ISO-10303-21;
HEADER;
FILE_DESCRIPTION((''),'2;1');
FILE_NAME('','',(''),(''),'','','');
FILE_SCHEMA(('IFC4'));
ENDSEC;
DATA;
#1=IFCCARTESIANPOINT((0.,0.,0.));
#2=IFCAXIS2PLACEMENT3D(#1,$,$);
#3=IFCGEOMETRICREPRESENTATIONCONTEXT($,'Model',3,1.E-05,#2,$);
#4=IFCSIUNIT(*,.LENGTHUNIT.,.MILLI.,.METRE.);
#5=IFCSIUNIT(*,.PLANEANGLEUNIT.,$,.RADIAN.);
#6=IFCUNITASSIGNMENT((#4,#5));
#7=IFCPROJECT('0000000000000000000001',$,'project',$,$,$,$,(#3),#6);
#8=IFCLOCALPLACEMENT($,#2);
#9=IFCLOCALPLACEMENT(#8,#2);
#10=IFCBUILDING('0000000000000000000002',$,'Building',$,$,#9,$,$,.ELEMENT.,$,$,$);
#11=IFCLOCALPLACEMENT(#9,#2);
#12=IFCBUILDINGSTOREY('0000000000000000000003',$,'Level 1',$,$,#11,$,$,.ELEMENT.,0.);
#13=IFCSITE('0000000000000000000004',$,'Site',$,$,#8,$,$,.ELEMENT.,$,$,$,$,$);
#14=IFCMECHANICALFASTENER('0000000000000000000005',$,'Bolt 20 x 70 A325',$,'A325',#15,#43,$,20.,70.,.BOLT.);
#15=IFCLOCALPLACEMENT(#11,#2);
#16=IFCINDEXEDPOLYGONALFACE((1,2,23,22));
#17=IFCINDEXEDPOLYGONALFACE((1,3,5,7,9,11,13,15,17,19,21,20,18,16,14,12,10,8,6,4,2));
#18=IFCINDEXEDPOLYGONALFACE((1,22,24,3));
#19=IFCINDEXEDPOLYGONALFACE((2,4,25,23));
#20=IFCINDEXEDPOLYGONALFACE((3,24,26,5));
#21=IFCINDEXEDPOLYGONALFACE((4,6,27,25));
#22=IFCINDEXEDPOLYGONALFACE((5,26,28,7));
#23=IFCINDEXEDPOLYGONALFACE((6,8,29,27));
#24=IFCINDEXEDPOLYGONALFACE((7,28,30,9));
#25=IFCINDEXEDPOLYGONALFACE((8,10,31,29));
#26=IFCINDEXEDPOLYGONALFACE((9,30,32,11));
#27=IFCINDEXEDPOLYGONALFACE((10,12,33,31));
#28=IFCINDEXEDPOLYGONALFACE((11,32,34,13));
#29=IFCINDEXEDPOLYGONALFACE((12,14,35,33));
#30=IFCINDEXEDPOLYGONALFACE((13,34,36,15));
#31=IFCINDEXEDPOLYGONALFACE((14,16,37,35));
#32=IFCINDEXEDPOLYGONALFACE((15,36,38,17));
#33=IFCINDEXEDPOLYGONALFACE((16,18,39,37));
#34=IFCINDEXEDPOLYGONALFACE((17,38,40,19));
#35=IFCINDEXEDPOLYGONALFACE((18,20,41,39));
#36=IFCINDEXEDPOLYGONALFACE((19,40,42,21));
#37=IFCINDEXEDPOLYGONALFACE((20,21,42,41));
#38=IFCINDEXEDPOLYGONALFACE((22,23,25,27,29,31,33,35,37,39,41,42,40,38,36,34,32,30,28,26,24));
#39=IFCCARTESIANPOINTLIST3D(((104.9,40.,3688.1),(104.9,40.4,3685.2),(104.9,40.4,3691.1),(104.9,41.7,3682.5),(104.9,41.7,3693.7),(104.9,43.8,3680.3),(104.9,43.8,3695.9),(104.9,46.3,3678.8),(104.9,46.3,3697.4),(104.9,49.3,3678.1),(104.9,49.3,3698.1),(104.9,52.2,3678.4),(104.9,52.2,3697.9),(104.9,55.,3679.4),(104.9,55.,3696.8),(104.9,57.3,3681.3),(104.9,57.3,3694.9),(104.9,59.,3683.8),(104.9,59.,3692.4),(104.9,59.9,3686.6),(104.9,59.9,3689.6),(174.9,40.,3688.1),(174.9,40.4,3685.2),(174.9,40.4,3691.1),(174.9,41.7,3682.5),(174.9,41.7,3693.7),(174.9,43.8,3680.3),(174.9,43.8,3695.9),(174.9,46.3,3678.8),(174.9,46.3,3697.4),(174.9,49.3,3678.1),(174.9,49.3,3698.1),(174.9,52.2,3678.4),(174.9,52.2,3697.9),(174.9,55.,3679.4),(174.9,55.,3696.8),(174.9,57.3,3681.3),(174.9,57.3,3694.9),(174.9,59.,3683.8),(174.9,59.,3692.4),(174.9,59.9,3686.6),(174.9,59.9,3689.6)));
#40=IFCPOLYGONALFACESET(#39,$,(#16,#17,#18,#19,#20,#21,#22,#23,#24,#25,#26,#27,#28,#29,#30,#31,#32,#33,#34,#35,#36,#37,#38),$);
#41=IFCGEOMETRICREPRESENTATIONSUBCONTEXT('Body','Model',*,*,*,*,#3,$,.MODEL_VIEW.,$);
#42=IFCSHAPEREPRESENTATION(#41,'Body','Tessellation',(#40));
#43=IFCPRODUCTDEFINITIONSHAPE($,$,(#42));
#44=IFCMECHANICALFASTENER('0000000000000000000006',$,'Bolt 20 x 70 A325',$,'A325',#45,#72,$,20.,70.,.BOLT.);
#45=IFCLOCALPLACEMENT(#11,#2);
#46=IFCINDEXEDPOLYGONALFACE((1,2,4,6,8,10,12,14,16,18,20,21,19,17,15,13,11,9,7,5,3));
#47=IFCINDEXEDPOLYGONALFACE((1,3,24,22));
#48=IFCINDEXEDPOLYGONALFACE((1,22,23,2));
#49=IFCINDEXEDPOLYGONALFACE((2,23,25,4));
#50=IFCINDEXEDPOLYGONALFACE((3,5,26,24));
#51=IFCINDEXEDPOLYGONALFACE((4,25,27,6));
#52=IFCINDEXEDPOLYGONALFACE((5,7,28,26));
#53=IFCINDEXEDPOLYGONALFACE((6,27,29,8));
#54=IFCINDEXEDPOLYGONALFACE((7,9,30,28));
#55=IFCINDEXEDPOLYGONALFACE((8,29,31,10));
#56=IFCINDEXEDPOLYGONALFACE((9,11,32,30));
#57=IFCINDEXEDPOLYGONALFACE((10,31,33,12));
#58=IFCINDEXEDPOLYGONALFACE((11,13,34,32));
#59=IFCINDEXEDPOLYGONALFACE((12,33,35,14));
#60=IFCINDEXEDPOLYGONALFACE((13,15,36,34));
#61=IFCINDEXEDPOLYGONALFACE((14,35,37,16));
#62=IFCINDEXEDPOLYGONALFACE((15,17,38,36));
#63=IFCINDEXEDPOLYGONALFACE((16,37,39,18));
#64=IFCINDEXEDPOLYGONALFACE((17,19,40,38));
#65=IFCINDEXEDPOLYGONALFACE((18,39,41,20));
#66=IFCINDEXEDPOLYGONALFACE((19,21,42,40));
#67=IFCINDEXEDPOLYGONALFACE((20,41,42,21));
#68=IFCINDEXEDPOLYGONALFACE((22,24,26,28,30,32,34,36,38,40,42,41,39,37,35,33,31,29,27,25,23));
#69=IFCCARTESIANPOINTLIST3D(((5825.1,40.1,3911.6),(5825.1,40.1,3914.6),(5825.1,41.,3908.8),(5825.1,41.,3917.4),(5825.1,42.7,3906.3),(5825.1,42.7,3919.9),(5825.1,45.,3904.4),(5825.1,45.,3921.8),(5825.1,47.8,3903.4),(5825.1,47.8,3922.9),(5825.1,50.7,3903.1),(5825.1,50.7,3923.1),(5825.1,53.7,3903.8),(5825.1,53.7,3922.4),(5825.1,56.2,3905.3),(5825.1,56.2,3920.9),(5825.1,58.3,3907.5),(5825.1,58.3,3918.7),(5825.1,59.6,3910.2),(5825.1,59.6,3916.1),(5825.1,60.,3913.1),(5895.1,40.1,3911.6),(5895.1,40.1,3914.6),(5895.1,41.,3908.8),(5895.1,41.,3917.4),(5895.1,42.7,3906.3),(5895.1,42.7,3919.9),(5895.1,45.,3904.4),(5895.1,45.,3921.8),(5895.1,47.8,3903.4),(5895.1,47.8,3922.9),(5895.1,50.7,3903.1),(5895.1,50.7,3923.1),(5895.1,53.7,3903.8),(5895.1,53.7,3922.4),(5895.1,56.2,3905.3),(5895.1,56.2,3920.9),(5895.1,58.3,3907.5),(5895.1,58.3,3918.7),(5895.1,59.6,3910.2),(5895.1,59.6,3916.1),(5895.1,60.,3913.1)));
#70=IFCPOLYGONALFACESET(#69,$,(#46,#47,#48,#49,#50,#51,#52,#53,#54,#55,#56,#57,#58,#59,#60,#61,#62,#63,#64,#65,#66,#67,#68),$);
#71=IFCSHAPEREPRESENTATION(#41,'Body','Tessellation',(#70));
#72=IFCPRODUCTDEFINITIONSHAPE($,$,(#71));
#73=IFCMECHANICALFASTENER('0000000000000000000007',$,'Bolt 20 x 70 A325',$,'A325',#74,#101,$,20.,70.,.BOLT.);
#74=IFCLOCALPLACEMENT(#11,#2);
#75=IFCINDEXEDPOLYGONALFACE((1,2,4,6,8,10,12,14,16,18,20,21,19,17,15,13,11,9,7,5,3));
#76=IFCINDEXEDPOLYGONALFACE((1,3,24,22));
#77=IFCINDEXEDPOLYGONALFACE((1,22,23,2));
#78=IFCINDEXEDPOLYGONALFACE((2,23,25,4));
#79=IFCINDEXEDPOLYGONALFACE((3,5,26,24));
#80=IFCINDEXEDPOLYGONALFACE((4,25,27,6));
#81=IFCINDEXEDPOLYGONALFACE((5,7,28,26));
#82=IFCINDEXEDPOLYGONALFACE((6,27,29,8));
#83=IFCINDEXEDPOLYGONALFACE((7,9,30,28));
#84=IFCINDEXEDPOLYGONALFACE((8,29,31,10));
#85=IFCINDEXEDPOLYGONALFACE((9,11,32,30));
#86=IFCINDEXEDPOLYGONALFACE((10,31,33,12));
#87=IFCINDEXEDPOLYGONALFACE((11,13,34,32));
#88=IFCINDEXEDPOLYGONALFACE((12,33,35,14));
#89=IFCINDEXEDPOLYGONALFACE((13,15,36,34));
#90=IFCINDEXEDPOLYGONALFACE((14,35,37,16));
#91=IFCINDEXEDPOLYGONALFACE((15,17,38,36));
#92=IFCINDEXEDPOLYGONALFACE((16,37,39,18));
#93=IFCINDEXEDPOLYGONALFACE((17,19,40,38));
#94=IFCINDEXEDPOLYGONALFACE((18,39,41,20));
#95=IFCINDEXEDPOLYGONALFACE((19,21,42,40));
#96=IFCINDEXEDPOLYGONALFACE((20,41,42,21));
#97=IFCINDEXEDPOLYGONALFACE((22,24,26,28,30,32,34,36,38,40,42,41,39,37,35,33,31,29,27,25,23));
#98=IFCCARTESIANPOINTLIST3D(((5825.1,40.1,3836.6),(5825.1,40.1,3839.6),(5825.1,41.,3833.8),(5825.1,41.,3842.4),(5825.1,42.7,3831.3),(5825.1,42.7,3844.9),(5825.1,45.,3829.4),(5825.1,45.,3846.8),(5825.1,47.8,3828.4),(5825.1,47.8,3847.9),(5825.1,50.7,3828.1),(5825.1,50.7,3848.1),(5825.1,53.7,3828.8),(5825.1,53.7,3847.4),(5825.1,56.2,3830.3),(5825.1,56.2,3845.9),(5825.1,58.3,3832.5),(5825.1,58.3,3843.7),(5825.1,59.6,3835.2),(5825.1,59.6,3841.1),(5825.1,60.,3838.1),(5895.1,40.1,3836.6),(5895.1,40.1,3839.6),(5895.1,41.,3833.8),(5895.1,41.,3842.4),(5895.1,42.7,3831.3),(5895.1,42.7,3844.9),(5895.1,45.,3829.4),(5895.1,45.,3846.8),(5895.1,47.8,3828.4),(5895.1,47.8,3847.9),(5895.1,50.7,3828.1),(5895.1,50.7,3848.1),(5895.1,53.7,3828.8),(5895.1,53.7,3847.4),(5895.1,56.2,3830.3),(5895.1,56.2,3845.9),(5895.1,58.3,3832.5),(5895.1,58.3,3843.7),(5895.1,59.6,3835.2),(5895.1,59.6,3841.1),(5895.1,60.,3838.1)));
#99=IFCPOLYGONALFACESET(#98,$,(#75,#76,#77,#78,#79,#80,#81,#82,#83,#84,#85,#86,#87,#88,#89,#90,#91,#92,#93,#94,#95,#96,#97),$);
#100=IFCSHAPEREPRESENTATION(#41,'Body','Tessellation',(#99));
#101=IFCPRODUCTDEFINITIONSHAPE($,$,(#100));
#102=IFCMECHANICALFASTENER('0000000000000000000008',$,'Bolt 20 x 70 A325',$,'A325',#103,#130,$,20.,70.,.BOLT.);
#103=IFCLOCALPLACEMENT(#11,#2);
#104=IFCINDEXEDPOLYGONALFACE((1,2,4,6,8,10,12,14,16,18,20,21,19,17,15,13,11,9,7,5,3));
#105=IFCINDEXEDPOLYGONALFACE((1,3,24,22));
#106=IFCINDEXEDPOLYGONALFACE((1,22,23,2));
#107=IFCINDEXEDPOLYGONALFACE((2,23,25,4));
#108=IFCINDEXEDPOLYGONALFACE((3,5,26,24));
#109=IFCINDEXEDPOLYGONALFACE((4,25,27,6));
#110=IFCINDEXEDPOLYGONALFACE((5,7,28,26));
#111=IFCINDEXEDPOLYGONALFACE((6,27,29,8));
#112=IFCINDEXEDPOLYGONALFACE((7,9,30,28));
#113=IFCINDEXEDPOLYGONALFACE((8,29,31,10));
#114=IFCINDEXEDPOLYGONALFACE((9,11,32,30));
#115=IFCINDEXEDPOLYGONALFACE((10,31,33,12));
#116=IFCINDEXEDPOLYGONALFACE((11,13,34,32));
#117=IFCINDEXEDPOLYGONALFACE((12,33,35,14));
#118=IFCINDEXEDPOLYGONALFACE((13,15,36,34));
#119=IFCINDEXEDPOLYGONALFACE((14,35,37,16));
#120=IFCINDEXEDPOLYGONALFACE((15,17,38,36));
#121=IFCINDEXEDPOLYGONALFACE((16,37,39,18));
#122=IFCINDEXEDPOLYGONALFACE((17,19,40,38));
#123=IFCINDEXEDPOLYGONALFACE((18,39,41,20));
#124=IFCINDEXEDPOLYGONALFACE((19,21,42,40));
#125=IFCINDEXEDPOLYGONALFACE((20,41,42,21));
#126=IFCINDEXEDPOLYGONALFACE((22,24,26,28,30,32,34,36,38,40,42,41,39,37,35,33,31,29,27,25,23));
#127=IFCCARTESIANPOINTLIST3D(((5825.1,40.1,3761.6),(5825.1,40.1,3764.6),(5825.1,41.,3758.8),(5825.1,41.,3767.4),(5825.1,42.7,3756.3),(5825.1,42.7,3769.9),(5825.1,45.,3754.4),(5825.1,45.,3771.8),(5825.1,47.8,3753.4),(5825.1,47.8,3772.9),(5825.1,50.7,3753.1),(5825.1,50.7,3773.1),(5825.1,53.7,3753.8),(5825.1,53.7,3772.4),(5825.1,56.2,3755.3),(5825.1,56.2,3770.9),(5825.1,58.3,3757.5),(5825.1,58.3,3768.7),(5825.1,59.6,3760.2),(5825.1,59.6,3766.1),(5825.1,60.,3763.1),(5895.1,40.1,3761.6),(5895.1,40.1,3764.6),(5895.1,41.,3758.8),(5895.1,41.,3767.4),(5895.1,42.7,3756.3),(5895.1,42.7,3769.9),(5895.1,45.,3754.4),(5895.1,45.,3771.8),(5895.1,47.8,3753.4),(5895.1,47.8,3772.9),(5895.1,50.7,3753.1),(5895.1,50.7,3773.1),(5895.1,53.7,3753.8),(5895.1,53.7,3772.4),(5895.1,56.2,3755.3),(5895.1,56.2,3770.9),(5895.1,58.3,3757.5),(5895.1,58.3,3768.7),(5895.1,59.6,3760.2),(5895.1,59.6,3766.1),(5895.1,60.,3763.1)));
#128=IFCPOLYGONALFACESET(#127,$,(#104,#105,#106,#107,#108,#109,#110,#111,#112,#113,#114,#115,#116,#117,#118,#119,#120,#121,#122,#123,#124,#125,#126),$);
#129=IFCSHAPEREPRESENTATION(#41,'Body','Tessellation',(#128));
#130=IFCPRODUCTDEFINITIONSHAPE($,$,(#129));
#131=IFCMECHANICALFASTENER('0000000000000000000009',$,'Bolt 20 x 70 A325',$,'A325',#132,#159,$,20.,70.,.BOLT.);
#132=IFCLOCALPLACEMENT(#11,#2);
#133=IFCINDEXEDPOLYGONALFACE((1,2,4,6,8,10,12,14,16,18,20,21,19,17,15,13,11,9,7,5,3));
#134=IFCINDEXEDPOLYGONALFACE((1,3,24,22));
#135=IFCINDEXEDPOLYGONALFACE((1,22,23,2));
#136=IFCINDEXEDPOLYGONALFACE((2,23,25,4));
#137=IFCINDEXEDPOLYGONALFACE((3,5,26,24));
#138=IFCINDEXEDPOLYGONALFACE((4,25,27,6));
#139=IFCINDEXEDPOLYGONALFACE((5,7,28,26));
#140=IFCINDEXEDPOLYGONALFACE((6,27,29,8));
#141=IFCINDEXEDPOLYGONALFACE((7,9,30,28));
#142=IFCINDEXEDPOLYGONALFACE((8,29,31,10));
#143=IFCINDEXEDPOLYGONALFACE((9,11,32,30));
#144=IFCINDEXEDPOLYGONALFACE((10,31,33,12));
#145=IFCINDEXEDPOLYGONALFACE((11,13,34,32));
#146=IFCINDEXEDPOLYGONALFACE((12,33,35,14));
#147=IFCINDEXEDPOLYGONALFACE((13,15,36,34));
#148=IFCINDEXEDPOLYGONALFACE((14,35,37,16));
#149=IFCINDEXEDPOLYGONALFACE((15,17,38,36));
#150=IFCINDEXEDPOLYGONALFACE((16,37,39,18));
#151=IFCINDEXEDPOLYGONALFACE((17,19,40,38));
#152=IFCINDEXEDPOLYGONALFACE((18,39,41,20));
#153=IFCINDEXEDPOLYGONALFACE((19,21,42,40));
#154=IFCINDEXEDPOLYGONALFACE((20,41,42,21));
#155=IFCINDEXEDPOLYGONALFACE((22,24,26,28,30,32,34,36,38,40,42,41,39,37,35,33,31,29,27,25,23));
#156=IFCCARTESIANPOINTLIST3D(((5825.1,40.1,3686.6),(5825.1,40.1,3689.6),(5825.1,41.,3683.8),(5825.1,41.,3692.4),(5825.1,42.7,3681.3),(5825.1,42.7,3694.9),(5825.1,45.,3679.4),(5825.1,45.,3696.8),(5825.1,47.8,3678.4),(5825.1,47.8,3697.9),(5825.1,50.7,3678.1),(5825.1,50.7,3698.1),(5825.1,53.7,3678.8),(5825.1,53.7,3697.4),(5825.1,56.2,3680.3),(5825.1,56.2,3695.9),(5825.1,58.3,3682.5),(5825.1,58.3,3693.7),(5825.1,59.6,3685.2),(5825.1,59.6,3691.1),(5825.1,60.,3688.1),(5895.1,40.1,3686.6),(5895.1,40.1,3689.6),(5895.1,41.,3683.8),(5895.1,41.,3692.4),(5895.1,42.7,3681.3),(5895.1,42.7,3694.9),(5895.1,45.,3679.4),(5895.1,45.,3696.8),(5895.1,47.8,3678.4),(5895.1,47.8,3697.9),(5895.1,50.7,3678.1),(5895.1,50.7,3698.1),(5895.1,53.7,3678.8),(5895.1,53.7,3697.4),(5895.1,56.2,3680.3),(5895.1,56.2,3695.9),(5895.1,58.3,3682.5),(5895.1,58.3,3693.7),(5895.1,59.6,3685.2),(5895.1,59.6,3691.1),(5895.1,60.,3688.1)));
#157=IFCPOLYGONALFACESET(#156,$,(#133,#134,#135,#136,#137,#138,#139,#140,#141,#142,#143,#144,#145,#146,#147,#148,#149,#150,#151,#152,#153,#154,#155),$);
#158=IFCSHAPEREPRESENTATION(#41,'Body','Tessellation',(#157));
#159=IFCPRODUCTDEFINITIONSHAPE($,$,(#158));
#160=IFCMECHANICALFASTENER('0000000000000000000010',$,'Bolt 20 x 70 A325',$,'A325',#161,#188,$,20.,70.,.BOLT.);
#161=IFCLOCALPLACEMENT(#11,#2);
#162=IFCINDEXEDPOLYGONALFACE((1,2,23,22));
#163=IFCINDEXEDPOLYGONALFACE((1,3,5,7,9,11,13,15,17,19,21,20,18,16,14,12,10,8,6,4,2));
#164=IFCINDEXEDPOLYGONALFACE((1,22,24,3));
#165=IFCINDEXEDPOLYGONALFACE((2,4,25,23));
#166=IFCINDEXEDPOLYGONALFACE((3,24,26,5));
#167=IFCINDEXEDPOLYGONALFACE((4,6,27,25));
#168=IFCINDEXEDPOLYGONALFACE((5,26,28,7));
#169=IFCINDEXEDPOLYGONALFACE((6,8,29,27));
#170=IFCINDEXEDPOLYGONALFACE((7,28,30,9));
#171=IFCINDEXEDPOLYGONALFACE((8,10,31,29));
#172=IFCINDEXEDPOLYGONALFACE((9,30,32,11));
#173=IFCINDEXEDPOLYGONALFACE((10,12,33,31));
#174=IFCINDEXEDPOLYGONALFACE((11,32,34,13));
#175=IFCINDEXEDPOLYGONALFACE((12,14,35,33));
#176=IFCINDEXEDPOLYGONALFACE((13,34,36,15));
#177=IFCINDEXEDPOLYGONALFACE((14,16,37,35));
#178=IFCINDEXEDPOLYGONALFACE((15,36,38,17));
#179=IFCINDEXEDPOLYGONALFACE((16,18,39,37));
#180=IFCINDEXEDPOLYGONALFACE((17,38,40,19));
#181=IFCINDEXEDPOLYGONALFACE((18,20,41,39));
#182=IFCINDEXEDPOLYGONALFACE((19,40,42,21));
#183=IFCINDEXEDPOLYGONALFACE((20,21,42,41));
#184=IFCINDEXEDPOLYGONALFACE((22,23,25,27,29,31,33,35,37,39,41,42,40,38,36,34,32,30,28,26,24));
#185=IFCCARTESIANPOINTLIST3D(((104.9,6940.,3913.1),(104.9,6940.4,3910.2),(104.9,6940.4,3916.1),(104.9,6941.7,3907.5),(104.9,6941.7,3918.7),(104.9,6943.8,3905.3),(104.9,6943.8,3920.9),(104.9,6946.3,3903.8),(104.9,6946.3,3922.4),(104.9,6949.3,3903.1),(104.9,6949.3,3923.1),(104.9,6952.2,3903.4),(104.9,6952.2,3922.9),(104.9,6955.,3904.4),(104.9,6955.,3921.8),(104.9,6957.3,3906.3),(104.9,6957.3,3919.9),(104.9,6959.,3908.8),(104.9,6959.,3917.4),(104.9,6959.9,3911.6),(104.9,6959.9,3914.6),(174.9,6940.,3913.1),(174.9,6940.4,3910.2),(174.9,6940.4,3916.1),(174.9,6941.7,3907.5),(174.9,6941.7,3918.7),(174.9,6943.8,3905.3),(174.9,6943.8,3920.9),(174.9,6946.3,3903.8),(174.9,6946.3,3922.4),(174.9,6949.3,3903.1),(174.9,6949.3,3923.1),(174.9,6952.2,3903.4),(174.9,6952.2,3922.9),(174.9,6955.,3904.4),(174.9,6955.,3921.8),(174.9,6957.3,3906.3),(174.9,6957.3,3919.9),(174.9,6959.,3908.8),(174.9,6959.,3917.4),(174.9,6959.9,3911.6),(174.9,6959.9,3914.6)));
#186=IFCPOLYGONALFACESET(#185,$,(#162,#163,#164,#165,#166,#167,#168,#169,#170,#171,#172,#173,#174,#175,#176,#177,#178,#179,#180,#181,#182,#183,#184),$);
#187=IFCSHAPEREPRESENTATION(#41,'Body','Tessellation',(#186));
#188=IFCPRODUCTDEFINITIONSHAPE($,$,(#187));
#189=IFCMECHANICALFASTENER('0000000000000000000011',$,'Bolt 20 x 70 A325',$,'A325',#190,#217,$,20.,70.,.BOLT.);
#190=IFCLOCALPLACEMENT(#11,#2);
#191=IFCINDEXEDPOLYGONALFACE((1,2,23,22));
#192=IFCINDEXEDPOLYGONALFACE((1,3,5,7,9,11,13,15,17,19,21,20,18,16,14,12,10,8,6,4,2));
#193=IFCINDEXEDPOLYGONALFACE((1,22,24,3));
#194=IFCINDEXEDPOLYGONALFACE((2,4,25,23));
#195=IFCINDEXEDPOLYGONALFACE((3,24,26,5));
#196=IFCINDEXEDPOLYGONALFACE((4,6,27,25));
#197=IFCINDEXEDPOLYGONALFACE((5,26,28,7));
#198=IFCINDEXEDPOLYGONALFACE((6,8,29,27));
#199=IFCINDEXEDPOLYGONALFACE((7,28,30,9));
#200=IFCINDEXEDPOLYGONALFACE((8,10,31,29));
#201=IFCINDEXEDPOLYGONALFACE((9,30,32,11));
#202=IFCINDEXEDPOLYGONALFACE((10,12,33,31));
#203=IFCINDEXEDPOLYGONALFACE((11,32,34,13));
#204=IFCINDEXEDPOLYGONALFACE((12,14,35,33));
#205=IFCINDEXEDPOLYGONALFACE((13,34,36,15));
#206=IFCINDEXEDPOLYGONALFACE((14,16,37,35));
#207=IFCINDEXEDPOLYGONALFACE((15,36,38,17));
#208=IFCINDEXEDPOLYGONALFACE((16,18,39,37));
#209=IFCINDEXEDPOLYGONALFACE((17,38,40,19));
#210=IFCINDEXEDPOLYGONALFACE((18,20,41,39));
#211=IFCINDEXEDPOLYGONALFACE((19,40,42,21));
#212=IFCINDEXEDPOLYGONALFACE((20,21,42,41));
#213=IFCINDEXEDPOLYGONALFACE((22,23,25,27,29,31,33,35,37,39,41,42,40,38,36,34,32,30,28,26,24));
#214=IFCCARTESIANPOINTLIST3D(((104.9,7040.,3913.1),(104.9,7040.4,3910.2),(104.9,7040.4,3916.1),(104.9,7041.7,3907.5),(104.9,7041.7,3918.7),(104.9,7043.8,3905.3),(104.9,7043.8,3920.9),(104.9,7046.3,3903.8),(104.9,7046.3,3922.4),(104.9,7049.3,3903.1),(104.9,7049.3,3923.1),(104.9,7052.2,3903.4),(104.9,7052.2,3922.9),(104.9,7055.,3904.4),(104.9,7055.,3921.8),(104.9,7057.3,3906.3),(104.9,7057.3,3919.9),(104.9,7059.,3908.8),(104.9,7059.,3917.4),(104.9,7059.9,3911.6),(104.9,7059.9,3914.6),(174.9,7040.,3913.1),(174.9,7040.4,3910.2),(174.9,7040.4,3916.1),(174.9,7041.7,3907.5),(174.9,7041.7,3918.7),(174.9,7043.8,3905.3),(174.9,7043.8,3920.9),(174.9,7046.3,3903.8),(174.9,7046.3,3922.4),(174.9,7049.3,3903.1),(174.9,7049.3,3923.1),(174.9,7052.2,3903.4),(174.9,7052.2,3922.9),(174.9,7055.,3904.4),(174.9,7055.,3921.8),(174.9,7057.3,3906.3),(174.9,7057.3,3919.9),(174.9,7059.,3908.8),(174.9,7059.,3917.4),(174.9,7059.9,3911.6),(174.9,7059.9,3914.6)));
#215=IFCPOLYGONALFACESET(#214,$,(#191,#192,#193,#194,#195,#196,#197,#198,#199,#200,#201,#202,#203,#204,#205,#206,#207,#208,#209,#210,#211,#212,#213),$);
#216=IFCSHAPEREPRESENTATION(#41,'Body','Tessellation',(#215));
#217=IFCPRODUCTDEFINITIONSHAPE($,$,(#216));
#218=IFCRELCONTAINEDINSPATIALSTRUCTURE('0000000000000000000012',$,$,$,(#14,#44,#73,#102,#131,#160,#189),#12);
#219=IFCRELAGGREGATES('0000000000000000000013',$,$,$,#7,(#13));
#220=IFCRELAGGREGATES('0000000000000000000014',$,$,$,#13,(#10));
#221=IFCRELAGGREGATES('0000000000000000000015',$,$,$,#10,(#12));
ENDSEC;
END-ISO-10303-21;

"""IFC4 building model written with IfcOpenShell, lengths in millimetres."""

from ifc_helpers import new_model, si_unit, frame, origin, origin_2d, place, context, subcontext, project, spatial, circle, extrude, element, save


model = new_model("IFC4")

# Units and contexts
model_context = context("Model", 3, precision=1e-05, world=origin())
body_context = subcontext(model_context, "Body", "Model", "MODEL_VIEW")
ifc_project = project(units=[si_unit("LENGTHUNIT", "METRE", prefix="MILLI"), si_unit("PLANEANGLEUNIT", "RADIAN")], contexts=[model_context])

# Site, building, storey
site_placement = place(None, origin())
site = spatial("IfcSite", under=ifc_project, at=site_placement, Name="Site", CompositionType="ELEMENT")
building_placement = place(site_placement, origin())
building = spatial("IfcBuilding", under=site, at=building_placement, Name="Building", CompositionType="ELEMENT")
storey_placement = place(building_placement, origin())
storey = spatial("IfcBuildingStorey", under=building, at=storey_placement, Name="Level 1", CompositionType="ELEMENT", Elevation=0.0)

# Mechanical fasteners
for number, where, z_axis, x_axis, name in (
    (1, (174.9, 50.0, 3688.1), (-1.0, 0.0, 0.0), (0.0, -1.0, 0.0), "Bolt 20 x 70 A325"),
    (2, (5825.1, 50.0, 3913.1), (1.0, 0.0, 0.0), (0.0, 1.0, 0.0), "Bolt 20 x 70 A325"),
    (3, (5825.1, 50.0, 3838.1), (1.0, 0.0, 0.0), (0.0, 1.0, 0.0), "Bolt 20 x 70 A325"),
    (4, (5825.1, 50.0, 3763.1), (1.0, 0.0, 0.0), (0.0, 1.0, 0.0), "Bolt 20 x 70 A325"),
    (5, (5825.1, 50.0, 3688.1), (1.0, 0.0, 0.0), (0.0, 1.0, 0.0), "Bolt 20 x 70 A325"),
    (6, (174.9, 6950.0, 3913.1), (-1.0, 0.0, 0.0), (0.0, -1.0, 0.0), "Bolt 20 x 70 A325"),
    (7, (174.9, 7050.0, 3913.1), (-1.0, 0.0, 0.0), (0.0, -1.0, 0.0), "Bolt 20 x 70 A325"),
):
    element("IfcMechanicalFastener", number, at=place(storey_placement, frame(where, z_axis=z_axis, x_axis=x_axis)), inside=storey, Name=name, ObjectType="A325", NominalDiameter=20.0, NominalLength=70.0, PredefinedType="BOLT", context=body_context, shape_type="SweptSolid", body=[
        extrude(circle(Radius=10.0, at=origin_2d()), origin(), (0.0, 0.0, 1.0), 70.0),
    ])

save(model, "model.ifc")
